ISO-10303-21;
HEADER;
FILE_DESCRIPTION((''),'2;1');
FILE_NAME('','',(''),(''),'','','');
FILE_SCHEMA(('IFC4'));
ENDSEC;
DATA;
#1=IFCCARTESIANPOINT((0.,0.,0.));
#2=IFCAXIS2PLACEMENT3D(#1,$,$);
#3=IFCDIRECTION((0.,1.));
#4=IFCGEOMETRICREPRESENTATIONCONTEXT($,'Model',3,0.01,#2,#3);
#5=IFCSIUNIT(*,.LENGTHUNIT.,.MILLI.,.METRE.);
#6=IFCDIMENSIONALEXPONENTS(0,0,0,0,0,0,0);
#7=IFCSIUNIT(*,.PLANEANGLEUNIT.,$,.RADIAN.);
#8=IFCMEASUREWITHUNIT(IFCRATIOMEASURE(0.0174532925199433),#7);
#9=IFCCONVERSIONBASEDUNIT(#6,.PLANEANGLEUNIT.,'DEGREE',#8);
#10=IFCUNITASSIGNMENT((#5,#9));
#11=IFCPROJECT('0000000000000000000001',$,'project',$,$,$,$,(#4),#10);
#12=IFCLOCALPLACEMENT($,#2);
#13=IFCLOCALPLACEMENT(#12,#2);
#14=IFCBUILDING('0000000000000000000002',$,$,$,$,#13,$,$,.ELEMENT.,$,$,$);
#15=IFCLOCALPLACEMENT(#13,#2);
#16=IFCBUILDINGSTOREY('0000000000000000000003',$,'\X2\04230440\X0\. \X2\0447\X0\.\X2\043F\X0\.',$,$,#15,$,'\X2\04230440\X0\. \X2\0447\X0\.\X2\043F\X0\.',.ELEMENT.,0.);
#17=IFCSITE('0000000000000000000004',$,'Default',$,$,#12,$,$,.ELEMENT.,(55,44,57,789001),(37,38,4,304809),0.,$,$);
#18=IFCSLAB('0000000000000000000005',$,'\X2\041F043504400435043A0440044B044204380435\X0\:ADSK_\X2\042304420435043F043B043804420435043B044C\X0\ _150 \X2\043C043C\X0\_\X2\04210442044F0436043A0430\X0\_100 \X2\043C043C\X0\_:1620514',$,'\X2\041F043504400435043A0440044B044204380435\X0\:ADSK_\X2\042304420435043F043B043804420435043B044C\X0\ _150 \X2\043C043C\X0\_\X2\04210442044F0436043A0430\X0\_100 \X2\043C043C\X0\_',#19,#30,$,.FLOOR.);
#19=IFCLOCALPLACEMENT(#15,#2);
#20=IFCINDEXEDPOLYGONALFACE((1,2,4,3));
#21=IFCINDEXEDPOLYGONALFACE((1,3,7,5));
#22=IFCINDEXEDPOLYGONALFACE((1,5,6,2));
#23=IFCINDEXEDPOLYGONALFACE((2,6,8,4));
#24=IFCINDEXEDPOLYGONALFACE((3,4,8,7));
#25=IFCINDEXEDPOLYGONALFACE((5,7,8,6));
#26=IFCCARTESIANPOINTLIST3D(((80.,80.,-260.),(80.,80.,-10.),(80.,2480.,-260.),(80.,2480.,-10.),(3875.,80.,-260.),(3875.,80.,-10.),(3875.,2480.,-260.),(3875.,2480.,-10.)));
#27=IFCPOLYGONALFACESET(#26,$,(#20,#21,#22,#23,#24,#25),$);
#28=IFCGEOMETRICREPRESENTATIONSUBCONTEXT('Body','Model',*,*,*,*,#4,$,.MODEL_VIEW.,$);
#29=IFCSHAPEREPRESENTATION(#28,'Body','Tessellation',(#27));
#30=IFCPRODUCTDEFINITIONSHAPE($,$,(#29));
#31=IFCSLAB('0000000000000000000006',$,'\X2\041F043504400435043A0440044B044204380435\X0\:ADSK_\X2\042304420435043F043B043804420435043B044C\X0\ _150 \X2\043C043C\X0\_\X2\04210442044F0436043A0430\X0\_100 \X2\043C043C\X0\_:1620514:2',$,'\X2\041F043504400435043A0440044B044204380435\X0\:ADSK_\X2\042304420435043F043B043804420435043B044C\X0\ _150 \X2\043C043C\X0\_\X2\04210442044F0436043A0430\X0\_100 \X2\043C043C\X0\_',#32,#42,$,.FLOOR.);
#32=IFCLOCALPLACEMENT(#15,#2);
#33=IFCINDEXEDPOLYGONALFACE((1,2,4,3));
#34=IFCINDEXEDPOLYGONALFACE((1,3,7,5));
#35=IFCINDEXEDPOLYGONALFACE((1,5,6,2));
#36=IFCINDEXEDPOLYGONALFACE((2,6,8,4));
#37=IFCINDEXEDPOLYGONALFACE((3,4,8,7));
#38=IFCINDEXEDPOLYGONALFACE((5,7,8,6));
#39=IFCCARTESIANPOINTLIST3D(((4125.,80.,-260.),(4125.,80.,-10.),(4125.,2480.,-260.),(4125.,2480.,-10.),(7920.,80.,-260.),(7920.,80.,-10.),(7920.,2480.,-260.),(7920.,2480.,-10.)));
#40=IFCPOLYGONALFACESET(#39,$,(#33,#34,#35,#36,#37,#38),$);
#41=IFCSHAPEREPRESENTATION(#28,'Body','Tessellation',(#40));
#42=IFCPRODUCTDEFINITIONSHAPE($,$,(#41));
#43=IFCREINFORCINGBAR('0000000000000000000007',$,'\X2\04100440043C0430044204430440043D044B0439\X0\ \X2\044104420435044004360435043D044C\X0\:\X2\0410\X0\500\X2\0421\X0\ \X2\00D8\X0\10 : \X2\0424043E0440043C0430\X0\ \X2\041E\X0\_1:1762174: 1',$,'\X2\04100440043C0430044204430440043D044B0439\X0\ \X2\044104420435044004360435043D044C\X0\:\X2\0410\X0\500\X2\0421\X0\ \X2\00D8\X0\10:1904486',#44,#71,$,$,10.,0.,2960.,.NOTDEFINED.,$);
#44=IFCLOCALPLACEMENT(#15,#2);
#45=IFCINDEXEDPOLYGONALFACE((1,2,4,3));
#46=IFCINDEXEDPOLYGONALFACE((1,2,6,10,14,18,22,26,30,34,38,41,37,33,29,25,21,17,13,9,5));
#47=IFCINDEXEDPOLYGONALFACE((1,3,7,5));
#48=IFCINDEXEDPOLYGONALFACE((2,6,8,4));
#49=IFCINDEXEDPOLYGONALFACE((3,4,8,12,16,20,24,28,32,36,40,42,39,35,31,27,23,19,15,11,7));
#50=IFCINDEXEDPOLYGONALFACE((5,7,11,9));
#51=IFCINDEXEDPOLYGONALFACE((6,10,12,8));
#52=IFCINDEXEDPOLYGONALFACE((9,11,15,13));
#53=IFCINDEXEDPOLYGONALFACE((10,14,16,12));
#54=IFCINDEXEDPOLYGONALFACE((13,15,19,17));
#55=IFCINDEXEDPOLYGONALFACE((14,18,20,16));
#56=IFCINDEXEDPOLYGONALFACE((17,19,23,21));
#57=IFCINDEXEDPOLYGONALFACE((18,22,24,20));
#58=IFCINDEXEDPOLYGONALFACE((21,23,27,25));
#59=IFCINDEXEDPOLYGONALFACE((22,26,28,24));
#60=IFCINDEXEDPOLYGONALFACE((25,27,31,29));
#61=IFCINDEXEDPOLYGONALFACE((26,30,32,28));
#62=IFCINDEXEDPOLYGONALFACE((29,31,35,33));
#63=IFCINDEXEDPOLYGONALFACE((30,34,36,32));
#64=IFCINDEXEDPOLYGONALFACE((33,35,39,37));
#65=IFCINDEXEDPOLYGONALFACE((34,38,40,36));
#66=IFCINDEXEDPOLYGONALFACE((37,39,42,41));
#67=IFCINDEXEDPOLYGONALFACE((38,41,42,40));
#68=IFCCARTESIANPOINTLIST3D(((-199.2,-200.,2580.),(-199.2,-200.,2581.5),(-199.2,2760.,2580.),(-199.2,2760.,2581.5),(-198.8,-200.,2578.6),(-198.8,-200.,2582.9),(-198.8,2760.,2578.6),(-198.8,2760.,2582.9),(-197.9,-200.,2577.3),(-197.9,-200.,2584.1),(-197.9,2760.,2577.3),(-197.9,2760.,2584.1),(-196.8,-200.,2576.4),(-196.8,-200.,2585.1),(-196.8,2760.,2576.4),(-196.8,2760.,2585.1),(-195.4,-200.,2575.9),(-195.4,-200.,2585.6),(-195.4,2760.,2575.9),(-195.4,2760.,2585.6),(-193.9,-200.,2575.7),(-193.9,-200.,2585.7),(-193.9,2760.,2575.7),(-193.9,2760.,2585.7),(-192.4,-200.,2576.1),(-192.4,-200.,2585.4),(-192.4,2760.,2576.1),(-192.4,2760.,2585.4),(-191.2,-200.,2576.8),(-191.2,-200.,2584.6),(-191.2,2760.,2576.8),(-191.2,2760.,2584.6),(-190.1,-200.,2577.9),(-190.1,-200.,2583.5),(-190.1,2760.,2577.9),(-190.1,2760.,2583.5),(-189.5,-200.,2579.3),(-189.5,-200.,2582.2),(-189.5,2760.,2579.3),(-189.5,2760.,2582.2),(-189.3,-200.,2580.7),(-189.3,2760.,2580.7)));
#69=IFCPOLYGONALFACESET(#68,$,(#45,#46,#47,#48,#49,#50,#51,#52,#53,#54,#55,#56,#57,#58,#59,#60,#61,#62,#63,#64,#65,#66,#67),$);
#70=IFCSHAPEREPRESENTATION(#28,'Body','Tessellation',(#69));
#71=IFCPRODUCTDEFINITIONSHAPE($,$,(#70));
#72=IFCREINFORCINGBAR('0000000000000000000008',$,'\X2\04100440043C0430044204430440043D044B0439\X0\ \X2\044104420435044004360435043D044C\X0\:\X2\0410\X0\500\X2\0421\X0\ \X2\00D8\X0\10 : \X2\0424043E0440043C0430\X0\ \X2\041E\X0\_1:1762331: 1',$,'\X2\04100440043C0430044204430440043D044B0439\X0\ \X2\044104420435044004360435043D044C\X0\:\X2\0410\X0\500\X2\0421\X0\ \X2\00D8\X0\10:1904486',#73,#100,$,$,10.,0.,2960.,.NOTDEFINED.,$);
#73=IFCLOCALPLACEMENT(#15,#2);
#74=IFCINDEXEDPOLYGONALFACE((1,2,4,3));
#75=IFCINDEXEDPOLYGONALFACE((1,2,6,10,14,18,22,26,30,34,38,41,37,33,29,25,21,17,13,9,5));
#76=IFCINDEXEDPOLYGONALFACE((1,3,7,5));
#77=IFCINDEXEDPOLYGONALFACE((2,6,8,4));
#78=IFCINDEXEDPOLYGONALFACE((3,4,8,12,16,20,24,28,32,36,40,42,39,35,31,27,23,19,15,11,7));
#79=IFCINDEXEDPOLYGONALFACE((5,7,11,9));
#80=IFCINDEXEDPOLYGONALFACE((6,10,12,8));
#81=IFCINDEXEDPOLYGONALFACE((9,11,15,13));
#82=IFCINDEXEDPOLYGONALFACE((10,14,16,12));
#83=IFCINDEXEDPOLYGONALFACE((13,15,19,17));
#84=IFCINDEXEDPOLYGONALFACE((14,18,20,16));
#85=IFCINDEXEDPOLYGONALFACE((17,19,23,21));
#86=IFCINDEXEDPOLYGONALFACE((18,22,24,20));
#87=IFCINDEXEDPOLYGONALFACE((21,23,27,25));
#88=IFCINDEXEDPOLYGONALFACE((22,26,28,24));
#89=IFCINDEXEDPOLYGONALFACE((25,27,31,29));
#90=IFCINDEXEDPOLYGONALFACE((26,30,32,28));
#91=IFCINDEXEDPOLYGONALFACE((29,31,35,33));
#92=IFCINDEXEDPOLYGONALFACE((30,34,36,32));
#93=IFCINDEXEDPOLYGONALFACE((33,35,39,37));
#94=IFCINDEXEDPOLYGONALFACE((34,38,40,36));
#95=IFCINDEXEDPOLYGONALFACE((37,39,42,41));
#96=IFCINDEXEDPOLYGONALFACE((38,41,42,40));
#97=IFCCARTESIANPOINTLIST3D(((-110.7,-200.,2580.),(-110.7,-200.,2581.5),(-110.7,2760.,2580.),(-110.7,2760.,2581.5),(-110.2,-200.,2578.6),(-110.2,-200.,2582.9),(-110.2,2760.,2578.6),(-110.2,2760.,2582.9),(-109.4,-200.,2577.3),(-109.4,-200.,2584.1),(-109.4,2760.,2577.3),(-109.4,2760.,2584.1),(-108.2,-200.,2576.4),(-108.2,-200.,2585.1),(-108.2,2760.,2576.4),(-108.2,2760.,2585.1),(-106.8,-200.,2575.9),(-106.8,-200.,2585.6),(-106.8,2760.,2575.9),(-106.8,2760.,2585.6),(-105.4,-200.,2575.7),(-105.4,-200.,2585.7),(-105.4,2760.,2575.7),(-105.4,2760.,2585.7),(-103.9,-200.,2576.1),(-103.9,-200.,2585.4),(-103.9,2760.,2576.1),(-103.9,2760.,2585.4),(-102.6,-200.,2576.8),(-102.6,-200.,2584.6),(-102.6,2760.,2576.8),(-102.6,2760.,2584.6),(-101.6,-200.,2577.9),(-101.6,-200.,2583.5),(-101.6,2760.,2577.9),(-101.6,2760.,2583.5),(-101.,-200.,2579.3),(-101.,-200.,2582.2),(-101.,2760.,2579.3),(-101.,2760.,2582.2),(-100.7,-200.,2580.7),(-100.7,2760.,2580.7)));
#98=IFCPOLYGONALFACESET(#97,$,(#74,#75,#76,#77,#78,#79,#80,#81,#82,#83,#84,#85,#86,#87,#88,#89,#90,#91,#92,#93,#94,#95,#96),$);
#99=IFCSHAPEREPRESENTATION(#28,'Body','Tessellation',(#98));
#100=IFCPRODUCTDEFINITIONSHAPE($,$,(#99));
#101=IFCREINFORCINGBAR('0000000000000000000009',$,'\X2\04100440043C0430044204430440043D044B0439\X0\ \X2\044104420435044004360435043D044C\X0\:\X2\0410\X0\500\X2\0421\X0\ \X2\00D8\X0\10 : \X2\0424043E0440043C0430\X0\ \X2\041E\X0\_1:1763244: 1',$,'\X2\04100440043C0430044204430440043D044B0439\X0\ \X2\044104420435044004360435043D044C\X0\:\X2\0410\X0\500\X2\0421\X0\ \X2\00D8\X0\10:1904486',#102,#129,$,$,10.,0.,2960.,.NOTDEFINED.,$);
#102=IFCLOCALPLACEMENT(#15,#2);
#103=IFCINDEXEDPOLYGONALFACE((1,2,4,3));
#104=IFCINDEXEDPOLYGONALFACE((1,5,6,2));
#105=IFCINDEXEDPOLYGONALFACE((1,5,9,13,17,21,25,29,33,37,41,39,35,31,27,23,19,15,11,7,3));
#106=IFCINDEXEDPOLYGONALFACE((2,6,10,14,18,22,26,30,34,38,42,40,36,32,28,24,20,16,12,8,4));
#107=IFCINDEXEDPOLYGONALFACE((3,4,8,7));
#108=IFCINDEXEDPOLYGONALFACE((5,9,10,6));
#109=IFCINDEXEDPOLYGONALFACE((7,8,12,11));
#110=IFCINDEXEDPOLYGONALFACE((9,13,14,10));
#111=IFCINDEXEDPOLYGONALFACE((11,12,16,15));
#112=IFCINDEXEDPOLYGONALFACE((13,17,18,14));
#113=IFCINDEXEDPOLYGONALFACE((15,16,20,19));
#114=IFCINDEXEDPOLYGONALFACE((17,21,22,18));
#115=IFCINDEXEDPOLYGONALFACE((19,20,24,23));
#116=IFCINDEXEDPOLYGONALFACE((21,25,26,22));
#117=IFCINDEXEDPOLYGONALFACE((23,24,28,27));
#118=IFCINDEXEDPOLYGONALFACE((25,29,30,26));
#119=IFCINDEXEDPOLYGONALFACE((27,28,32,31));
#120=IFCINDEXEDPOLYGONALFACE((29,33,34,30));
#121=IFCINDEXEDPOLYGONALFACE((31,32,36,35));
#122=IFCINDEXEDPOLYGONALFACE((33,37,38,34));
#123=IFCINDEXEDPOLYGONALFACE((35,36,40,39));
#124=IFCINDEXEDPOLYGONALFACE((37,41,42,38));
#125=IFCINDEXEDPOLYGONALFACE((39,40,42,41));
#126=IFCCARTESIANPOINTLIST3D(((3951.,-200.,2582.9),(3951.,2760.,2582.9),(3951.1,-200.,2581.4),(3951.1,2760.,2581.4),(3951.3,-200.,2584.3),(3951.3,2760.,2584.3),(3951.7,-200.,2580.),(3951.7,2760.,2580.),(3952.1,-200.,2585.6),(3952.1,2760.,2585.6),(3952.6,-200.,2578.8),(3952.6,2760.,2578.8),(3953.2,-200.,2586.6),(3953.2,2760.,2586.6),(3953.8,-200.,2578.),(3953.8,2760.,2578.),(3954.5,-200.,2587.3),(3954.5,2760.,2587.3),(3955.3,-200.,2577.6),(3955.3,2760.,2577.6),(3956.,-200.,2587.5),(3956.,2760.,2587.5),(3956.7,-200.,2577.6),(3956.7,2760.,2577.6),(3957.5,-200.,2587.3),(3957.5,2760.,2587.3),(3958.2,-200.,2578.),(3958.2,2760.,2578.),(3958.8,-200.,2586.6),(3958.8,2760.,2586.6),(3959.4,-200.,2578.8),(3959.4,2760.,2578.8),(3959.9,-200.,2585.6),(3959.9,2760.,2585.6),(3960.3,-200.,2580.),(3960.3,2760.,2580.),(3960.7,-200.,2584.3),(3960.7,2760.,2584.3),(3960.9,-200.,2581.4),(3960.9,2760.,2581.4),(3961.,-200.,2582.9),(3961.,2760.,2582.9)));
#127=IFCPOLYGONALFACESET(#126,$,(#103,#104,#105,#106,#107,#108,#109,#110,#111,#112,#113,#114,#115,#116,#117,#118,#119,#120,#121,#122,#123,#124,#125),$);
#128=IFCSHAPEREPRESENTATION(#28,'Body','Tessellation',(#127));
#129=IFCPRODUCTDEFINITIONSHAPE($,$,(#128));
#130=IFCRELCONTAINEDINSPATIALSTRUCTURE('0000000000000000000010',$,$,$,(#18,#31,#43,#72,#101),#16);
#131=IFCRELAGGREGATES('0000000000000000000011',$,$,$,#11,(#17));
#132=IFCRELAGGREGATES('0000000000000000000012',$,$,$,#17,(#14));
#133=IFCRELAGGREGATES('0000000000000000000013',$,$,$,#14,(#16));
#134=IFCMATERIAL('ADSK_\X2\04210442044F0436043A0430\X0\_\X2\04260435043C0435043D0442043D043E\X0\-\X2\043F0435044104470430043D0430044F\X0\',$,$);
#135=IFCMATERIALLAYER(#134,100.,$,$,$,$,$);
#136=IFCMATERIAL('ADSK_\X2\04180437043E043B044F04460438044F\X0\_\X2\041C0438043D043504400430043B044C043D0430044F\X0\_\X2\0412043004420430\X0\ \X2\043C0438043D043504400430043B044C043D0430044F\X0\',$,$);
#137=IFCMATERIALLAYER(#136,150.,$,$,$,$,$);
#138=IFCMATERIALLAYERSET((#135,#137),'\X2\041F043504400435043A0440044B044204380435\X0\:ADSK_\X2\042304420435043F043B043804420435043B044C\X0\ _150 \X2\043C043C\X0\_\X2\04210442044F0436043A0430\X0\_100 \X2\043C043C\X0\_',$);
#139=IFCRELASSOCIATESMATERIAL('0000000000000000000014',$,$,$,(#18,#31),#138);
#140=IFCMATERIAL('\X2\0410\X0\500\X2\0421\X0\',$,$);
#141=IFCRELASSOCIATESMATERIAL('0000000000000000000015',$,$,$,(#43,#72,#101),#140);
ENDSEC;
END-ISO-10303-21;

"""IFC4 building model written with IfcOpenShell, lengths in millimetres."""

from ifc_helpers import new_model, entity, si_unit, converted_unit, direction, frame, frame_2d, origin, place, context, subcontext, project, spatial, rectangle, extrude, material, layer, layer_set, layer_usage, element, save


model = new_model("IFC4")

# Units and contexts
model_context = context("Model", 3, precision=0.01, world=origin(), true_north=direction((0.0, 1.0)))
body_context = subcontext(model_context, "Body", "Model", "MODEL_VIEW")
ifc_project = project(units=[si_unit("LENGTHUNIT", "METRE", prefix="MILLI"), converted_unit("PLANEANGLEUNIT", "DEGREE", entity("IfcRatioMeasure", 0.0174532925199433), si_unit("PLANEANGLEUNIT", "RADIAN"), dimensions=[0, 0, 0, 0, 0, 0, 0])], contexts=[model_context])

# Site, building, storey
site_placement = place(None, origin())
site = spatial("IfcSite", under=ifc_project, at=site_placement, Name="Default", CompositionType="ELEMENT", RefLatitude=(55, 44, 57, 789001), RefLongitude=(37, 38, 4, 304809), RefElevation=0.0)
building_placement = place(site_placement, origin())
building = spatial("IfcBuilding", under=site, at=building_placement, CompositionType="ELEMENT")
storey_placement = place(building_placement, origin())
storey = spatial("IfcBuildingStorey", under=building, at=storey_placement, Name="Ур. ч.п.", LongName="Ур. ч.п.", CompositionType="ELEMENT", Elevation=0.0)

# Slabs
ifc_material_1 = material(Name="ADSK_Стяжка_Цементно-песчаная")
ifc_layer_1 = layer(ifc_material_1, 100.0)
ifc_material_2 = material(Name="ADSK_Изоляция_Минеральная_Вата минеральная")
ifc_layer_2 = layer(ifc_material_2, 150.0)
ifc_layer_set = layer_set([ifc_layer_1, ifc_layer_2], Name="Перекрытие:ADSK_Утеплитель _150 мм_Стяжка_100 мм_")
ifc_layer_usage = layer_usage(ifc_layer_set, "AXIS3", "POSITIVE", 0.0)
slab_1_placement = place(storey_placement, frame((80.0, 80.0, -260.0)))
element("IfcSlab", 1, at=slab_1_placement, inside=storey, material=ifc_layer_usage, Name="Перекрытие:ADSK_Утеплитель _150 мм_Стяжка_100 мм_:1620514", ObjectType="Перекрытие:ADSK_Утеплитель _150 мм_Стяжка_100 мм_", PredefinedType="FLOOR", context=body_context, shape_type="SweptSolid", body=[
    extrude(rectangle(XDim=2400.0, YDim=3795.0, at=frame_2d((2022.5, 0.0), x_axis=(0.0, -1.0))), frame((3920.0, 1200.0, 250.0), z_axis=(0.0, 0.0, -1.0), x_axis=(-1.0, 0.0, 0.0)), (0.0, 0.0, 1.0), 250.0),
])
slab_2_placement = place(storey_placement, frame((80.0, 80.0, -260.0)))
element("IfcSlab", 2, at=slab_2_placement, inside=storey, material=ifc_layer_usage, Name="Перекрытие:ADSK_Утеплитель _150 мм_Стяжка_100 мм_:1620514:2", ObjectType="Перекрытие:ADSK_Утеплитель _150 мм_Стяжка_100 мм_", PredefinedType="FLOOR", context=body_context, shape_type="SweptSolid", body=[
    extrude(rectangle(XDim=2400.0, YDim=3795.0, at=frame_2d((-2022.5, 0.0), x_axis=(0.0, -1.0))), frame((3920.0, 1200.0, 250.0), z_axis=(0.0, 0.0, -1.0), x_axis=(-1.0, 0.0, 0.0)), (0.0, 0.0, 1.0), 250.0),
])

# Reinforcing bars
ifc_material_3 = material(Name="А500С")
reinforcing_bar_1_placement = place(storey_placement, origin())
element("IfcReinforcingBar", 3, at=reinforcing_bar_1_placement, inside=storey, material=ifc_material_3, Name="Арматурный стержень:А500С Ø10 : Форма О_1:1762174: 1", ObjectType="Арматурный стержень:А500С Ø10:1904486", BarLength=2960.0, CrossSectionArea=0.0, NominalDiameter=10.0, PredefinedType="NOTDEFINED", context=body_context, shape_type="AdvancedSweptSolid", body=[
    entity("IfcSweptDiskSolid", entity("IfcCompositeCurve", [entity("IfcCompositeCurveSegment", "CONTINUOUS", True, entity("IfcPolyline", [entity("IfcCartesianPoint", [-194.3, -200.0, 2580.7]), entity("IfcCartesianPoint", [-194.3, 2760.0, 2580.7])]))], False), 5.0, None, 0.0, 1.0),
])
reinforcing_bar_2_placement = place(storey_placement, origin())
element("IfcReinforcingBar", 4, at=reinforcing_bar_2_placement, inside=storey, material=ifc_material_3, Name="Арматурный стержень:А500С Ø10 : Форма О_1:1762331: 1", ObjectType="Арматурный стержень:А500С Ø10:1904486", BarLength=2960.0, CrossSectionArea=0.0, NominalDiameter=10.0, PredefinedType="NOTDEFINED", context=body_context, shape_type="AdvancedSweptSolid", body=[
    entity("IfcSweptDiskSolid", entity("IfcCompositeCurve", [entity("IfcCompositeCurveSegment", "CONTINUOUS", True, entity("IfcPolyline", [entity("IfcCartesianPoint", [-105.7, -200.0, 2580.7]), entity("IfcCartesianPoint", [-105.7, 2760.0, 2580.7])]))], False), 5.0, None, 0.0, 1.0),
])
reinforcing_bar_3_placement = place(storey_placement, origin())
element("IfcReinforcingBar", 5, at=reinforcing_bar_3_placement, inside=storey, material=ifc_material_3, Name="Арматурный стержень:А500С Ø10 : Форма О_1:1763244: 1", ObjectType="Арматурный стержень:А500С Ø10:1904486", BarLength=2960.0, CrossSectionArea=0.0, NominalDiameter=10.0, PredefinedType="NOTDEFINED", context=body_context, shape_type="AdvancedSweptSolid", body=[
    entity("IfcSweptDiskSolid", entity("IfcCompositeCurve", [entity("IfcCompositeCurveSegment", "CONTINUOUS", True, entity("IfcPolyline", [entity("IfcCartesianPoint", [3956.0, -200.0, 2582.5]), entity("IfcCartesianPoint", [3956.0, 2760.0, 2582.5])]))], False), 5.0, None, 0.0, 1.0),
])

save(model, "model.ifc")
